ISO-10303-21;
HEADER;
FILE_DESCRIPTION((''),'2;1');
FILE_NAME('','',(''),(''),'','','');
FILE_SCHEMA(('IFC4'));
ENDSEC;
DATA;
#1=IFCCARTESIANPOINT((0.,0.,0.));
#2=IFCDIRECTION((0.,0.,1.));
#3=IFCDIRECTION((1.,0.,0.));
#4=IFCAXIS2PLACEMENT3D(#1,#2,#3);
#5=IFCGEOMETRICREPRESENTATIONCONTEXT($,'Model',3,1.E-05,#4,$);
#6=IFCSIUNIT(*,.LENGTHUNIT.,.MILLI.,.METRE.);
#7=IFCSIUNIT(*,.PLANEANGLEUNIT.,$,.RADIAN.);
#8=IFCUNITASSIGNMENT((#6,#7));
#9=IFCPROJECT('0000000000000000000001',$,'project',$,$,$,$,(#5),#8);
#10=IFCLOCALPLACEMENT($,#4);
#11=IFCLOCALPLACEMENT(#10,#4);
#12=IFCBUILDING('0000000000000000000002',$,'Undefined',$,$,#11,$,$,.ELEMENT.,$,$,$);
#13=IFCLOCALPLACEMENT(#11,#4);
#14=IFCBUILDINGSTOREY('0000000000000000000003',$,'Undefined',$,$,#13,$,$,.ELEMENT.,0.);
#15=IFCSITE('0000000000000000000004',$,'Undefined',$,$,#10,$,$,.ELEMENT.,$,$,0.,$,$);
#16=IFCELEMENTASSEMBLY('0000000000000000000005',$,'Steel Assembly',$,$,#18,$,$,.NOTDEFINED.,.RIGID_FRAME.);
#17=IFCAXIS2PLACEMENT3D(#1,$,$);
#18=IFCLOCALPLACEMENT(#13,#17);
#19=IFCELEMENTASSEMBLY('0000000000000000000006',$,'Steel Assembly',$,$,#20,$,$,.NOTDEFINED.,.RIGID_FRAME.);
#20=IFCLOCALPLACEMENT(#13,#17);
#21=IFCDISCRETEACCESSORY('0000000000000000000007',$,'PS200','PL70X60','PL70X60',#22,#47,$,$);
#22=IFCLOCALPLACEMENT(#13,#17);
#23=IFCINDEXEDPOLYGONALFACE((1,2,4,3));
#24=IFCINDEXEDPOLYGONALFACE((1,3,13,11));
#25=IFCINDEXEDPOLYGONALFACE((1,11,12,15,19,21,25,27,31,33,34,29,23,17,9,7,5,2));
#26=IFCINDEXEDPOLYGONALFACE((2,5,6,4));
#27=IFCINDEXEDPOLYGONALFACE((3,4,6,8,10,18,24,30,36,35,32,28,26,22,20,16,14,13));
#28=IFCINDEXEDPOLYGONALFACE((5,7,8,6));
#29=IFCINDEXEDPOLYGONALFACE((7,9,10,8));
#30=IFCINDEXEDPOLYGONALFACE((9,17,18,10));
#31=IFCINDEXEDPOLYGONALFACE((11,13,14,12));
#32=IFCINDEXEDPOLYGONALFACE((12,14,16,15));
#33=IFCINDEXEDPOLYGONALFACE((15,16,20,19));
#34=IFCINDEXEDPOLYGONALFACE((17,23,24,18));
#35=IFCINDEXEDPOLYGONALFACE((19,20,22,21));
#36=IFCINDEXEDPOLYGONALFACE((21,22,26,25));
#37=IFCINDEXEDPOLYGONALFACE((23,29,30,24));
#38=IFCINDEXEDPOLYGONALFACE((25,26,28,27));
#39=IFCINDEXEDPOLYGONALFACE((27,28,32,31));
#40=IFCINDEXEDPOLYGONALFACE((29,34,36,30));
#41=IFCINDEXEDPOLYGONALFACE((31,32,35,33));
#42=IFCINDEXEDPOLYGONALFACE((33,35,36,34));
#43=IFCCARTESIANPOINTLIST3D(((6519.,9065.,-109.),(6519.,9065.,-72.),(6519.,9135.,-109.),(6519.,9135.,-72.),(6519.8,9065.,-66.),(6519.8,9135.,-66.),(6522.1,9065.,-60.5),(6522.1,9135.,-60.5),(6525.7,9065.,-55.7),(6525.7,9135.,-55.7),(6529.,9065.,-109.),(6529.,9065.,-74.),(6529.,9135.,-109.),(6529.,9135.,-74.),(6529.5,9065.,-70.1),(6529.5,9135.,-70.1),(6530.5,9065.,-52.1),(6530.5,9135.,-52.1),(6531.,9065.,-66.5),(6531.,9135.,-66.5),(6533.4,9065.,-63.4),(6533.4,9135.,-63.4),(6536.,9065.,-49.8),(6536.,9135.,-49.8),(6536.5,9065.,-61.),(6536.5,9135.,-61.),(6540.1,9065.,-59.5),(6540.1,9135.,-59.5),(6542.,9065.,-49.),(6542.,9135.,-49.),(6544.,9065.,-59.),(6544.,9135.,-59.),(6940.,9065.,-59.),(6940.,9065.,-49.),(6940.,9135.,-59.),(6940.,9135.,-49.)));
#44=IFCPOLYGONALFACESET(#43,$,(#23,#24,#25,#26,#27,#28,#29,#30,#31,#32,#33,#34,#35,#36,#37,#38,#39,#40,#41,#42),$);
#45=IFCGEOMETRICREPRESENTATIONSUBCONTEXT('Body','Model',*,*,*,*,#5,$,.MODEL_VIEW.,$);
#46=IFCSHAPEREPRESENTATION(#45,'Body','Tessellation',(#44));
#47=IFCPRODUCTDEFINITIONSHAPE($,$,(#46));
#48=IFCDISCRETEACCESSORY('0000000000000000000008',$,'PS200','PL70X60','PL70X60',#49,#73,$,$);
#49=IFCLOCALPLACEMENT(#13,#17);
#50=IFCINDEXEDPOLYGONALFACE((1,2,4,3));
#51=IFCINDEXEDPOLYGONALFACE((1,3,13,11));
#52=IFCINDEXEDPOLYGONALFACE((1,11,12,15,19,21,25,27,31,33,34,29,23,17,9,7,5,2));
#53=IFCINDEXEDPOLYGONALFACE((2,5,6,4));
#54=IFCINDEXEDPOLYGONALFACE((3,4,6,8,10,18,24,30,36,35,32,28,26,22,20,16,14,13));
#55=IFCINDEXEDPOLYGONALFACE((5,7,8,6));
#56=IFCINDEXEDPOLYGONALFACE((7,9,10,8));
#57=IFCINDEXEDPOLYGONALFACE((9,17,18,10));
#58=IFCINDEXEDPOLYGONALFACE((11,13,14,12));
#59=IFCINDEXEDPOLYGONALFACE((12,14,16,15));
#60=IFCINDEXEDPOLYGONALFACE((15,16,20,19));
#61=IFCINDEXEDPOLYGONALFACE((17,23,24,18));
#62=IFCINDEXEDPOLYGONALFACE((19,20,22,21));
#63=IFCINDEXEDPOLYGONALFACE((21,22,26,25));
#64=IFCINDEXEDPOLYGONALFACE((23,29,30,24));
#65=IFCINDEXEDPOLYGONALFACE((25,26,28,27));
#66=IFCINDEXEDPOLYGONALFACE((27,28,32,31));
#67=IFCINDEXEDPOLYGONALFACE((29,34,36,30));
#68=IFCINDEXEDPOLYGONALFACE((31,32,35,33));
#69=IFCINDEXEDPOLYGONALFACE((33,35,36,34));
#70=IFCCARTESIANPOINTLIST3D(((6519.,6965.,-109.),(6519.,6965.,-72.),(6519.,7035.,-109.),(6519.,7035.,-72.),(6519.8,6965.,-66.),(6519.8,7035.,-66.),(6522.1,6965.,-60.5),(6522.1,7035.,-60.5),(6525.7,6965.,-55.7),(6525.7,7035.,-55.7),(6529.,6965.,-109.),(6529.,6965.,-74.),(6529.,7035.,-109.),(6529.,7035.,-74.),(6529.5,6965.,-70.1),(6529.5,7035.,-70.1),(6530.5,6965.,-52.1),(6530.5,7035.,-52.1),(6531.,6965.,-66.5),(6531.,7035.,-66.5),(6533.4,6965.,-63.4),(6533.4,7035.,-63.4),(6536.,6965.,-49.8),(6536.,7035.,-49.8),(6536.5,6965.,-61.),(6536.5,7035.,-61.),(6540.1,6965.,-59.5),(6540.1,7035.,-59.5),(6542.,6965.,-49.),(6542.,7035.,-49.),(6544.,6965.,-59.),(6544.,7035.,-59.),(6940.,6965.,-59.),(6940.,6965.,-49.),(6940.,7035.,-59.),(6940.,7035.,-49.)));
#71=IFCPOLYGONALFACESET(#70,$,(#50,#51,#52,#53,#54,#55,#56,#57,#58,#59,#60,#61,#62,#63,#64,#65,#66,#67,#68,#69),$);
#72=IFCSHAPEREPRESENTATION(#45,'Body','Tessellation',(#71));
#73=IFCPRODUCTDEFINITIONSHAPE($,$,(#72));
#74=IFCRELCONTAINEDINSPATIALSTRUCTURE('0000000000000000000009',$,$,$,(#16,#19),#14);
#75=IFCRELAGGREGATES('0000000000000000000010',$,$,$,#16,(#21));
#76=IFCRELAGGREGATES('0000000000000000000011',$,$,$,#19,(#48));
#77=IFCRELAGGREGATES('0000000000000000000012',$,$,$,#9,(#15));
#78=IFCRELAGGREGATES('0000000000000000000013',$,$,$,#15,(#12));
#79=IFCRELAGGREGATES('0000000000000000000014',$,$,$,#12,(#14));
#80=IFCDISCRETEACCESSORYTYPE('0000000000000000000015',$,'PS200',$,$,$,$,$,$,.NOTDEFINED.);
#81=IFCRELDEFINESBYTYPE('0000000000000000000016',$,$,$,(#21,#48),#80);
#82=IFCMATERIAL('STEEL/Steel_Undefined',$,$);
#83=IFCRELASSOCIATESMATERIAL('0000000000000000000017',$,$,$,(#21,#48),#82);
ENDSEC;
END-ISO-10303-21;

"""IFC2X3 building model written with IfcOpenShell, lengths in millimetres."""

from ifc_helpers import new_model, si_unit, frame, frame_2d, origin_with_axes, place, context, subcontext, project, spatial, polyline, circle_curve, parameter, trimmed, segment, composite_curve, outline, extrude, material, type_object, element, aggregate, save


model = new_model("IFC2X3")

# Units and contexts
model_context = context("Model", 3, precision=1e-05, world=origin_with_axes())
body_context = subcontext(model_context, "Body", "Model", "MODEL_VIEW")
ifc_project = project(units=[si_unit("LENGTHUNIT", "METRE", prefix="MILLI"), si_unit("PLANEANGLEUNIT", "RADIAN")], contexts=[model_context])

# Site, building, storey
site_placement = place(None, origin_with_axes())
site = spatial("IfcSite", under=ifc_project, at=site_placement, Name="Undefined", CompositionType="ELEMENT", RefElevation=0.0)
building_placement = place(site_placement, origin_with_axes())
building = spatial("IfcBuilding", under=site, at=building_placement, Name="Undefined", CompositionType="ELEMENT")
storey_placement = place(building_placement, origin_with_axes())
storey = spatial("IfcBuildingStorey", under=building, at=storey_placement, Name="Undefined", CompositionType="ELEMENT", Elevation=0.0)

# Shared definitions
ifc_material_1 = material(Name="STEEL/Steel_Undefined")

# Element assemblies
assembly_1_placement = place(storey_placement, origin_with_axes())
assembly_1 = element("IfcElementAssembly", 1, at=assembly_1_placement, inside=storey, Name="Steel Assembly", AssemblyPlace="NOTDEFINED", PredefinedType="RIGID_FRAME")
assembly_2_placement = place(storey_placement, origin_with_axes())
assembly_2 = element("IfcElementAssembly", 2, at=assembly_2_placement, inside=storey, Name="Steel Assembly", AssemblyPlace="NOTDEFINED", PredefinedType="RIGID_FRAME")

# Discrete accessories
discrete_accessory_type_1 = type_object("IfcDiscreteAccessoryType", Name="PS200")
discrete_accessory_1_placement = place(assembly_1_placement, frame((6940.0, 9100.0, -49.0), z_axis=(0.0, -1.0, 0.0), x_axis=(-1.0, 0.0, 0.0)))
discrete_accessory_1 = element("IfcDiscreteAccessory", 3, at=discrete_accessory_1_placement, type_object=discrete_accessory_type_1, material=ifc_material_1, Name="PS200", Description="PL70X60", ObjectType="PL70X60", context=body_context, shape_type="SweptSolid", body=[
    extrude(outline(composite_curve([segment(polyline([(0.0, 0.0), (398.0, 0.0)]), True, "CONTINUOUS"), segment(trimmed(circle_curve(frame_2d((398.0, 23.0), x_axis=(0.0, -1.0)), 23.0), [parameter(0.0)], [parameter(1.570796)], True, "PARAMETER"), True, "CONTINUOUS"), segment(polyline([(421.0, 23.0), (421.0, 60.0), (411.0, 60.0), (411.0, 25.0)]), True, "CONTINUOUS"), segment(trimmed(circle_curve(frame_2d((396.0, 25.0), x_axis=(1.0, 0.0)), 15.0), [parameter(0.0)], [parameter(4.712389)], False, "PARAMETER"), True, "CONTINUOUS"), segment(polyline([(396.0, 10.0), (0.0, 10.0), (0.0, 0.0)]), True, "CONTINUOUS")], self_intersect=True)), frame((0.0, 0.0, -35.0), z_axis=(0.0, 0.0, 1.0), x_axis=(1.0, 0.0, 0.0)), (0.0, 0.0, 1.0), 70.0),
])
discrete_accessory_2_placement = place(assembly_2_placement, frame((6940.0, 7000.0, -49.0), z_axis=(0.0, -1.0, 0.0), x_axis=(-1.0, 0.0, 0.0)))
discrete_accessory_2 = element("IfcDiscreteAccessory", 4, at=discrete_accessory_2_placement, type_object=discrete_accessory_type_1, material=ifc_material_1, Name="PS200", Description="PL70X60", ObjectType="PL70X60", context=body_context, shape_type="SweptSolid", body=[
    extrude(outline(composite_curve([segment(polyline([(0.0, 0.0), (398.0, 0.0)]), True, "CONTINUOUS"), segment(trimmed(circle_curve(frame_2d((398.0, 23.0), x_axis=(0.0, -1.0)), 23.0), [parameter(0.0)], [parameter(1.570796)], True, "PARAMETER"), True, "CONTINUOUS"), segment(polyline([(421.0, 23.0), (421.0, 60.0), (411.0, 60.0), (411.0, 25.0)]), True, "CONTINUOUS"), segment(trimmed(circle_curve(frame_2d((396.0, 25.0), x_axis=(1.0, 0.0)), 15.0), [parameter(0.0)], [parameter(4.712389)], False, "PARAMETER"), True, "CONTINUOUS"), segment(polyline([(396.0, 10.0), (0.0, 10.0), (0.0, 0.0)]), True, "CONTINUOUS")], self_intersect=True)), frame((0.0, 0.0, -35.0), z_axis=(0.0, 0.0, 1.0), x_axis=(1.0, 0.0, 0.0)), (0.0, 0.0, 1.0), 70.0),
])

aggregate(assembly_1, [discrete_accessory_1])
aggregate(assembly_2, [discrete_accessory_2])

save(model, "model.ifc")
